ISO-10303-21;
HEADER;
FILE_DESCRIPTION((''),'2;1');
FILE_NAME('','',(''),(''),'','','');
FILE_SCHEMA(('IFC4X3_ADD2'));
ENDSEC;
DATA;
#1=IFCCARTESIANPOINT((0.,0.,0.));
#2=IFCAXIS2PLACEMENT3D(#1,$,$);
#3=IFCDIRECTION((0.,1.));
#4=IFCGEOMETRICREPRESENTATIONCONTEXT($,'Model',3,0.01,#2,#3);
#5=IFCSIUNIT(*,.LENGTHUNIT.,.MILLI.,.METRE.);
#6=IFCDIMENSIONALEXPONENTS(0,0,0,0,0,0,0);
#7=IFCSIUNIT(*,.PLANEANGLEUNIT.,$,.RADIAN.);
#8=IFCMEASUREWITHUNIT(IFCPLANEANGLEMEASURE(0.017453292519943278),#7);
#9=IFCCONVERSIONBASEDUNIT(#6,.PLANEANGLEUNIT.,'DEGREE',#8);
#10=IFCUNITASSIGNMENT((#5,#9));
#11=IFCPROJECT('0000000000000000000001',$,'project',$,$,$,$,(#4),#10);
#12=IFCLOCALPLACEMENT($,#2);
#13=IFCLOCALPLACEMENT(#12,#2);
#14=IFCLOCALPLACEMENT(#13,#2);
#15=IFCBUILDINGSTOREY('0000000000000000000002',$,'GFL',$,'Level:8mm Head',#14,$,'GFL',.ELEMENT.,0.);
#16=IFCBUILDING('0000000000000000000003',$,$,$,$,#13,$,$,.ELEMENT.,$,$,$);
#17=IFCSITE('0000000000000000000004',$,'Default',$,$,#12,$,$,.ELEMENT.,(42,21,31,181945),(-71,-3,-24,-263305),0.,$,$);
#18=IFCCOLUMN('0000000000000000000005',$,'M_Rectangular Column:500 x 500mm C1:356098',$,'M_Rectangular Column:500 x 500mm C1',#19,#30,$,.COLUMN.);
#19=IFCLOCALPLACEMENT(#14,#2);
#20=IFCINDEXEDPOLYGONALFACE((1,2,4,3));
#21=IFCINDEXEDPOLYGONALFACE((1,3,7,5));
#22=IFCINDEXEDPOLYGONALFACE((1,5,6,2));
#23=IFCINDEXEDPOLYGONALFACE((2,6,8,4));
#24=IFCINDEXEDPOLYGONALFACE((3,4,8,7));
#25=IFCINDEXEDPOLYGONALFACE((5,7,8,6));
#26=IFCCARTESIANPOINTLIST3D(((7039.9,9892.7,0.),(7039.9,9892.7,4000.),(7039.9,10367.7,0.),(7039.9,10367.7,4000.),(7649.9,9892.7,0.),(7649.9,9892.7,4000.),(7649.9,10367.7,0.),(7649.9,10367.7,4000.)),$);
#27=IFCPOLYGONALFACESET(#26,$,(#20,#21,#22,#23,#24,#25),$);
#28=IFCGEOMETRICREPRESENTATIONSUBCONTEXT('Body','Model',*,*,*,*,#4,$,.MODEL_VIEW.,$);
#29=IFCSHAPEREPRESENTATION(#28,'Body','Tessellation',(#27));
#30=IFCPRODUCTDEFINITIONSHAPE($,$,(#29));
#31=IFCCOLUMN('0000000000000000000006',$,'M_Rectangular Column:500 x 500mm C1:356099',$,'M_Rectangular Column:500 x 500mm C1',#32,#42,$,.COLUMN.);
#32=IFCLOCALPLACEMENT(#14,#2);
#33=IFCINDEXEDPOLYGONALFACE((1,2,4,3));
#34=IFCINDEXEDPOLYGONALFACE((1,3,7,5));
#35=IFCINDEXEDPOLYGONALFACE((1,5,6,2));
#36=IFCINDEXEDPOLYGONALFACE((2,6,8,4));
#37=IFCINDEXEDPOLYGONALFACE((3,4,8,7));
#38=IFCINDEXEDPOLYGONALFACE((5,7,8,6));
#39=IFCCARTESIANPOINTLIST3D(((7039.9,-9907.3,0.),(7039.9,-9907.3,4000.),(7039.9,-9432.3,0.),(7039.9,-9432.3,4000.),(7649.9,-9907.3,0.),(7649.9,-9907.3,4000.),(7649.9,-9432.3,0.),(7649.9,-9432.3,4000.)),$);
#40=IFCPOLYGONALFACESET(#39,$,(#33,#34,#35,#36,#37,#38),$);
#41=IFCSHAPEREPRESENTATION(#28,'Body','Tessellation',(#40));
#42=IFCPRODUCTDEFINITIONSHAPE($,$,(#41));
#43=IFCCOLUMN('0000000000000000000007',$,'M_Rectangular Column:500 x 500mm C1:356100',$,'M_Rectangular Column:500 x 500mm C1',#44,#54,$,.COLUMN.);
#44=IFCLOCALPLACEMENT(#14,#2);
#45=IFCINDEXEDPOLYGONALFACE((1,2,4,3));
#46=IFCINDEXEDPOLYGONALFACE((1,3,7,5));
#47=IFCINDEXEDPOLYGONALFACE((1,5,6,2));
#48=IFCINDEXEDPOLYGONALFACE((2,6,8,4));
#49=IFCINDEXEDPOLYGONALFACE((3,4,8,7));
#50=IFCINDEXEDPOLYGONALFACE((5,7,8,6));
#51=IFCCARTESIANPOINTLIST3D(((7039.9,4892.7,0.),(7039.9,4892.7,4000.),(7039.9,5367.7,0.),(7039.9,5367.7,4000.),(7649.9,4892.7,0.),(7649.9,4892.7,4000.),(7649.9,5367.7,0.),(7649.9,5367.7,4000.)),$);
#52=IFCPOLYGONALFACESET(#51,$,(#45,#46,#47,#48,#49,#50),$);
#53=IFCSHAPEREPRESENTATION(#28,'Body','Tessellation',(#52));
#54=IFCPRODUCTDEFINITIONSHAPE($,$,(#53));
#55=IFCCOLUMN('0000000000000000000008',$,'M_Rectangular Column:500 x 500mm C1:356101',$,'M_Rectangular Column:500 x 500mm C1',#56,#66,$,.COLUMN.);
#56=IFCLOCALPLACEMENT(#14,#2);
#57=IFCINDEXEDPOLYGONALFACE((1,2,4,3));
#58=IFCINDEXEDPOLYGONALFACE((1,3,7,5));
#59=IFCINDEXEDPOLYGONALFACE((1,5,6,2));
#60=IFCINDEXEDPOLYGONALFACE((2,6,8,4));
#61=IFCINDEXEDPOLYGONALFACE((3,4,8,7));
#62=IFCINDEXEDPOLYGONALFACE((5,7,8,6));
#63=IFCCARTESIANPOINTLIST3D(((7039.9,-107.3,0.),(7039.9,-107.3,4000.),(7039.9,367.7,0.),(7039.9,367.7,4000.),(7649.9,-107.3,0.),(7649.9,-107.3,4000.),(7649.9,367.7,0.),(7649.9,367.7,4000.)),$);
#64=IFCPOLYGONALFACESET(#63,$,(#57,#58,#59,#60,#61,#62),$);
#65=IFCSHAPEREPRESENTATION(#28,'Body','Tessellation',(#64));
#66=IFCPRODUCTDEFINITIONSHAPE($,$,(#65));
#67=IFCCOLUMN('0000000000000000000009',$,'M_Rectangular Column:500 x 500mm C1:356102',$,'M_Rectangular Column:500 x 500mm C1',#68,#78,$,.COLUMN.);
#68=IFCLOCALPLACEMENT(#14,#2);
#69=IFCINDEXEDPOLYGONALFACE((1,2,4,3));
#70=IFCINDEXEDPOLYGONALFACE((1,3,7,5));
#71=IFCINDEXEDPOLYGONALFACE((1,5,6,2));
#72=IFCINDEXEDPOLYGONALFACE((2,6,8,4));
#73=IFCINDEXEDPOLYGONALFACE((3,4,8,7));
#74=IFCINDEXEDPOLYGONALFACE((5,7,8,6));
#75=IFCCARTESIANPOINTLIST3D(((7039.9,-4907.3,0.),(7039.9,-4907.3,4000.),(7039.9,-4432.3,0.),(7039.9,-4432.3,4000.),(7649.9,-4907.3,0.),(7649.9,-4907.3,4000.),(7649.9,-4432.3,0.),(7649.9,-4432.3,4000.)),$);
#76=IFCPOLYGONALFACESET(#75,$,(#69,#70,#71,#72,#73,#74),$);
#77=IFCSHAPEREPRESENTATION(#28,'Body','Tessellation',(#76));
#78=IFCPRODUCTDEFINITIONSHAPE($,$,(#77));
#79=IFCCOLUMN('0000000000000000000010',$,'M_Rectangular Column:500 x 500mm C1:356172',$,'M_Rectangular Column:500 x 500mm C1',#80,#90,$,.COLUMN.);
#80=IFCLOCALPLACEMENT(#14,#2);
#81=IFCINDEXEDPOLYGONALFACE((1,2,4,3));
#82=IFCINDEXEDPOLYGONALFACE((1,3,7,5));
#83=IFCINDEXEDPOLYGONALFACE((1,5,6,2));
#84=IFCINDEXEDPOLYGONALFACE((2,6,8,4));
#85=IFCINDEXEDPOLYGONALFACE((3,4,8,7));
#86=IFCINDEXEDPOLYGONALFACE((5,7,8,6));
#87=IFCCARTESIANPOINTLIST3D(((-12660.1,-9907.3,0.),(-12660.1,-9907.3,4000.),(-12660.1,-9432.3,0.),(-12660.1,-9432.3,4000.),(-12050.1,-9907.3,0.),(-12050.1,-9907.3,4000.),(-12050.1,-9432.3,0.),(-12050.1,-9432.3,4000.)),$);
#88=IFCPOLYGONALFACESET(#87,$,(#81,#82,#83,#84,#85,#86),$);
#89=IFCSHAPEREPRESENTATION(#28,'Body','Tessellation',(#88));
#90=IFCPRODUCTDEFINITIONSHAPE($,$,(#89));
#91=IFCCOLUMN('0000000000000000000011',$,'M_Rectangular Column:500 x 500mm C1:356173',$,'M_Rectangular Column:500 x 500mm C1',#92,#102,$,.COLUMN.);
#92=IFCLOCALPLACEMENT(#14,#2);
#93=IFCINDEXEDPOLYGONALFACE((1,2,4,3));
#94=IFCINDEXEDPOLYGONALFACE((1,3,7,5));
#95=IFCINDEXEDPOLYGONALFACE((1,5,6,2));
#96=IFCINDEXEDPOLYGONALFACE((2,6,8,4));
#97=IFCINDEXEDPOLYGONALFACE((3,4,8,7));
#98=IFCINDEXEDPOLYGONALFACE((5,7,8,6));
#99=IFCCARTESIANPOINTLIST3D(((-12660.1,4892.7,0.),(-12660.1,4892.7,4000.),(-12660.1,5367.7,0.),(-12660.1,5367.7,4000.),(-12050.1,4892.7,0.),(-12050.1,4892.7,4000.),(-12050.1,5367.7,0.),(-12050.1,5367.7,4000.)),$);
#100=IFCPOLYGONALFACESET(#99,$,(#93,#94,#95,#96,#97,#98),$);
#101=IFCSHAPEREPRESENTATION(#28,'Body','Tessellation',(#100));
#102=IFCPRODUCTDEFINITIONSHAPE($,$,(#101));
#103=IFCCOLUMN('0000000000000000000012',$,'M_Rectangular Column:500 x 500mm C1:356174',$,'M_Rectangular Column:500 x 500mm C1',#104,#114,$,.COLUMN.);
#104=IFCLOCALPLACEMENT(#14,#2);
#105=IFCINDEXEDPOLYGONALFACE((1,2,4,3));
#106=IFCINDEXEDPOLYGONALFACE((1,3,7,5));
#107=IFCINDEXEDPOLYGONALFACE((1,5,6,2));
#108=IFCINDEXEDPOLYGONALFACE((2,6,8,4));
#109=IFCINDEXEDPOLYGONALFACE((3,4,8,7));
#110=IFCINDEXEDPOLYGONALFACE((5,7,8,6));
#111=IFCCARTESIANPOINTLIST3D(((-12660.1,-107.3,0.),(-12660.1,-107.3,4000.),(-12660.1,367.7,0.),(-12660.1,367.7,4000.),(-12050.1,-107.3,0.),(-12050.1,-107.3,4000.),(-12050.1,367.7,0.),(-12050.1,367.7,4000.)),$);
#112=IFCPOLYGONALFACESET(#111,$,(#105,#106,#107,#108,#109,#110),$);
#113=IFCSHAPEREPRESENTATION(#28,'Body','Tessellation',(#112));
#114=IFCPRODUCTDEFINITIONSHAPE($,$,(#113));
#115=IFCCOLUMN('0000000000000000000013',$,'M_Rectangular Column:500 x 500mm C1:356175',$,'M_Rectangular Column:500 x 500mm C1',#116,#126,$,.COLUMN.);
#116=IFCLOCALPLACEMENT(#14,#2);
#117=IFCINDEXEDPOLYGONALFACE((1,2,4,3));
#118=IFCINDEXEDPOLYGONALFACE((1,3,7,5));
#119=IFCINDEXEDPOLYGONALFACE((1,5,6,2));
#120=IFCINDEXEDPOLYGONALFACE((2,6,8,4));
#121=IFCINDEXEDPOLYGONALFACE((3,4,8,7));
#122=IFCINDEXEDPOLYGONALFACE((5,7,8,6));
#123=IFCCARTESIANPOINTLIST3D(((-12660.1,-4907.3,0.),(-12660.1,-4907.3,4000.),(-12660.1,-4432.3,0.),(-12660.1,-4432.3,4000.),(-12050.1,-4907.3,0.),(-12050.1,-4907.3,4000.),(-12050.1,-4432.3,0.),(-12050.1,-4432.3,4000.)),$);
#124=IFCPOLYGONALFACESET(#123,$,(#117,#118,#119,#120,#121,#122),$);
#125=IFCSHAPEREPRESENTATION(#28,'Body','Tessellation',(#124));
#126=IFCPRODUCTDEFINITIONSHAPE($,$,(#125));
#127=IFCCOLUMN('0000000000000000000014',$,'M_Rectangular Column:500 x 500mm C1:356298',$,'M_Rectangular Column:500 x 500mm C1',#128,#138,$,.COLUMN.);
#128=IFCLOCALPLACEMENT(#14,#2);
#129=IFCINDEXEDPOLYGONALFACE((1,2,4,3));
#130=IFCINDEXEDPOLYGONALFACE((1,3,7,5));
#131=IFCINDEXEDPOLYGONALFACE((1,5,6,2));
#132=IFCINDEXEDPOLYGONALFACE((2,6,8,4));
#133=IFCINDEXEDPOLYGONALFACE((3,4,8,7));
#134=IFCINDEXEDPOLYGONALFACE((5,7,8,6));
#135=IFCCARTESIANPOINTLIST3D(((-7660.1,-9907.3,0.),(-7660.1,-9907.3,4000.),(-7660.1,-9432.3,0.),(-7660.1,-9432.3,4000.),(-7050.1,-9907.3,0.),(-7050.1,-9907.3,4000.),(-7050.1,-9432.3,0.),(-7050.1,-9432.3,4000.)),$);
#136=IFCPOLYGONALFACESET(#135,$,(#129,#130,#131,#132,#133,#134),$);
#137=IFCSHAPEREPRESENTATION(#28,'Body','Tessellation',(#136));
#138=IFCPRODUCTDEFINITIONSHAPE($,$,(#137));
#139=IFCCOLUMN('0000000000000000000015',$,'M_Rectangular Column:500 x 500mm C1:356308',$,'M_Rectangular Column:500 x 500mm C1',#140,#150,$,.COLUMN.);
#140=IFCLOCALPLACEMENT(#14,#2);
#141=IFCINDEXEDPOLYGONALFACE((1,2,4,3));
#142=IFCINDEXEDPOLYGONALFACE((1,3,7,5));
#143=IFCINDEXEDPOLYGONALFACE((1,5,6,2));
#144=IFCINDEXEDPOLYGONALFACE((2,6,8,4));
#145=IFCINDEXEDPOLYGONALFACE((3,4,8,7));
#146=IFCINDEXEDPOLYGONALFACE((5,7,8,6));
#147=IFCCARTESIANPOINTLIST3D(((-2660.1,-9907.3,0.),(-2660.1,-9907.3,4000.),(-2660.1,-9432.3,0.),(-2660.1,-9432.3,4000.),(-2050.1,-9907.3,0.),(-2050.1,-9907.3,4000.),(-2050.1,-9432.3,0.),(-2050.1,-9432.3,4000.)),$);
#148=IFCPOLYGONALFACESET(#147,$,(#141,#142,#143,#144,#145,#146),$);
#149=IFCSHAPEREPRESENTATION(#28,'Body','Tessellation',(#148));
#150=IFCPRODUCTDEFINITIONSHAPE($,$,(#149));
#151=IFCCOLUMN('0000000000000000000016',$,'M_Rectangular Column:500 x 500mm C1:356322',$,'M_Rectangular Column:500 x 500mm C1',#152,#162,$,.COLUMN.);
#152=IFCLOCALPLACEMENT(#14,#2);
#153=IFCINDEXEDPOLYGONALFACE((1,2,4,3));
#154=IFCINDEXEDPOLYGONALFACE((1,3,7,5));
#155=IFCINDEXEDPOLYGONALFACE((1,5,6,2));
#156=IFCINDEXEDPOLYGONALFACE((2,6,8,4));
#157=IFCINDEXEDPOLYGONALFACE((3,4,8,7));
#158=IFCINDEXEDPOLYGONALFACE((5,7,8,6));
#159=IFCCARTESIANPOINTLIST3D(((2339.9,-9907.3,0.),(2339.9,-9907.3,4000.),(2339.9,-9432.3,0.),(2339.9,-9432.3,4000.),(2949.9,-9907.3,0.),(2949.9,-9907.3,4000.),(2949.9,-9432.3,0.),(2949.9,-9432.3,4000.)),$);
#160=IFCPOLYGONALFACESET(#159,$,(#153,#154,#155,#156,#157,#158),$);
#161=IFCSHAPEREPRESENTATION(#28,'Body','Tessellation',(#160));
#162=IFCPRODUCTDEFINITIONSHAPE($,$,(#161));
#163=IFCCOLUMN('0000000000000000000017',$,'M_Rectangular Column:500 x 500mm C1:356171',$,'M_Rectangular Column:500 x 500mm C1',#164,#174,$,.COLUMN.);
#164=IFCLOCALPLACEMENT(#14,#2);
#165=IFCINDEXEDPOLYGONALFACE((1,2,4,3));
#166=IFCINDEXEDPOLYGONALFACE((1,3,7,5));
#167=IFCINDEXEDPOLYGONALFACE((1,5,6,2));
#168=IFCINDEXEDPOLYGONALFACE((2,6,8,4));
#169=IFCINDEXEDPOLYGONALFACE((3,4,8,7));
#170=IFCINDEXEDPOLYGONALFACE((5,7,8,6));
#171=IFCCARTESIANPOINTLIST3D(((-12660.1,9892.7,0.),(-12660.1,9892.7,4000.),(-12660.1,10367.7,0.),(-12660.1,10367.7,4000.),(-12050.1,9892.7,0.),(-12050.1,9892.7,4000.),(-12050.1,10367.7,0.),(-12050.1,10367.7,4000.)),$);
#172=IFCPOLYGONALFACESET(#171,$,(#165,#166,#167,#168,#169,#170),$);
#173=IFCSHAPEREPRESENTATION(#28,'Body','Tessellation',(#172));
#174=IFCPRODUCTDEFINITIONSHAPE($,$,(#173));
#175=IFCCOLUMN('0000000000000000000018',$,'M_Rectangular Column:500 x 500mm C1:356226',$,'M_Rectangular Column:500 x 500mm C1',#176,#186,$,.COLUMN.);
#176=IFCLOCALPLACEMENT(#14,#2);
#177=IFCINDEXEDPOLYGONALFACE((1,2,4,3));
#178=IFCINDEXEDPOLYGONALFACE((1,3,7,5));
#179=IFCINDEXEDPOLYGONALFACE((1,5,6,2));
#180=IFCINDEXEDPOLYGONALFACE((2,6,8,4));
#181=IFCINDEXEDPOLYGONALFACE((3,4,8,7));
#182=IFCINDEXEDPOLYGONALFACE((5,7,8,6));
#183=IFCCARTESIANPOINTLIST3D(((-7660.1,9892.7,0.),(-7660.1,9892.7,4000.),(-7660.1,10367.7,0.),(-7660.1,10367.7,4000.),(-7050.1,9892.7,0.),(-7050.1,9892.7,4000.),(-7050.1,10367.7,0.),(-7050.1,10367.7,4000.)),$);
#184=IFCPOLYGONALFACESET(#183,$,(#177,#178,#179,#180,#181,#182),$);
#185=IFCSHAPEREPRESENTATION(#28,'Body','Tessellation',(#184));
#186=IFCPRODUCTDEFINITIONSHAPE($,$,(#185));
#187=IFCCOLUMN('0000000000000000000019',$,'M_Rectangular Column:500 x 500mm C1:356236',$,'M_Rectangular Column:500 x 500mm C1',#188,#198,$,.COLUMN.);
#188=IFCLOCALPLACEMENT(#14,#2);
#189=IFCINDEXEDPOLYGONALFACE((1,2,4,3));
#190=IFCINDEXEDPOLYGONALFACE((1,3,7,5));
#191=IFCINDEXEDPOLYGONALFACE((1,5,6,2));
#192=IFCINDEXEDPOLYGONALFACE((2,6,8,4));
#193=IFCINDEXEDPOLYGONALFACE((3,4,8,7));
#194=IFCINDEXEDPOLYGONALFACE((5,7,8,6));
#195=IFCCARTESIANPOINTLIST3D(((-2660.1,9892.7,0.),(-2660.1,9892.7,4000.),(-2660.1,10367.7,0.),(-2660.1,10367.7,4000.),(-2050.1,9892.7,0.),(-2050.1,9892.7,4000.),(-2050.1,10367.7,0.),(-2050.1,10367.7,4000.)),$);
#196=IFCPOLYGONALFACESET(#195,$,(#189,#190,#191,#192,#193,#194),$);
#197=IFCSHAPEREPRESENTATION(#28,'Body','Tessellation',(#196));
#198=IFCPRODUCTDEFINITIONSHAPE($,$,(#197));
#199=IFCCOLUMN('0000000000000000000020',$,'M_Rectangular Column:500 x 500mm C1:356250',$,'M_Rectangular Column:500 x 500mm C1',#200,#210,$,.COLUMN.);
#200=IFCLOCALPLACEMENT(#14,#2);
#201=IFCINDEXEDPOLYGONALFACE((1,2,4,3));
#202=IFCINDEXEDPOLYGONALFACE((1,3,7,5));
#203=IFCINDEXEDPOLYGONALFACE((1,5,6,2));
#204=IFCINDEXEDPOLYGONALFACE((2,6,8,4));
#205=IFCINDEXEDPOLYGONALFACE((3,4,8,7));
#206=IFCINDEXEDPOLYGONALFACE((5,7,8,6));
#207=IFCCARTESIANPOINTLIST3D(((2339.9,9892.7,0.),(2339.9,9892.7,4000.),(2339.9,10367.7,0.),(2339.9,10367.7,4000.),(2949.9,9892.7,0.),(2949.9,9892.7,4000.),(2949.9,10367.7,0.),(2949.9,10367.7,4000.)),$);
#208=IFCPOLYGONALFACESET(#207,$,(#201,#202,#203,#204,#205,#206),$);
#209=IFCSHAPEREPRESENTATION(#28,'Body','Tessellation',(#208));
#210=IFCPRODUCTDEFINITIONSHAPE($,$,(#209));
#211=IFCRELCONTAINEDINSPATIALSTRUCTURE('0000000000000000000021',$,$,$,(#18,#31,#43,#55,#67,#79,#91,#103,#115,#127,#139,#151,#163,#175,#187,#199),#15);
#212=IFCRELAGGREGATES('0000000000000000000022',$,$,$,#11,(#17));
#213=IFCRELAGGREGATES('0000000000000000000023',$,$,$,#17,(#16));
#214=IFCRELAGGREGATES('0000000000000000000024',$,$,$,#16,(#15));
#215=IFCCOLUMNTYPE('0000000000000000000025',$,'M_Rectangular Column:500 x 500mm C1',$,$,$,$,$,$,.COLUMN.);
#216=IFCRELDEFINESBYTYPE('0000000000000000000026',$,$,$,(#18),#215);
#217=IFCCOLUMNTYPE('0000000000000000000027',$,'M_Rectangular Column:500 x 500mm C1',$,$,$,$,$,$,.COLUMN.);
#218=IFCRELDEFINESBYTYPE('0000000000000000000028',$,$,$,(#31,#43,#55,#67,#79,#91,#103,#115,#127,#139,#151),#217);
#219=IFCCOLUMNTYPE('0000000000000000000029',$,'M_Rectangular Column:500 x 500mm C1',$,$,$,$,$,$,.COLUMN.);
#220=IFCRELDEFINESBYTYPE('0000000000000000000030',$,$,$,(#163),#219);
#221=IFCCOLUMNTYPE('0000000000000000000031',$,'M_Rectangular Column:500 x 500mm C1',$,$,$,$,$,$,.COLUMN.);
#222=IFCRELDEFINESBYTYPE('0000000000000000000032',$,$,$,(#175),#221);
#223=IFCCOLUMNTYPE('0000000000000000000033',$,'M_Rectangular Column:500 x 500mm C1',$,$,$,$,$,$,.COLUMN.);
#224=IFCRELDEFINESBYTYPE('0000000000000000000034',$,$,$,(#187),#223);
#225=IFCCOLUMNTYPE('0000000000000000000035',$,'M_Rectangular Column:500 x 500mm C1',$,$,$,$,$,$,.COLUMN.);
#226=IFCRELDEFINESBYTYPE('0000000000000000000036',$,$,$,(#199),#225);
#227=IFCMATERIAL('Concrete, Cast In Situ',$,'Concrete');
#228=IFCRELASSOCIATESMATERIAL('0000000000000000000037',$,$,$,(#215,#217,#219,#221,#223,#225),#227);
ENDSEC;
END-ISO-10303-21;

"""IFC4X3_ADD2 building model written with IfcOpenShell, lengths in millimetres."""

from ifc_helpers import new_model, entity, si_unit, converted_unit, direction, frame, frame_2d, origin, origin_2d_with_axis, place, context, subcontext, project, spatial, rectangle, extrude, source, transform, mapped, material, material_profile, profile_set, type_object, type_shapes, element, save


model = new_model("IFC4X3_ADD2")

# Units and contexts
model_context = context("Model", 3, precision=0.01, world=origin(), true_north=direction((0.0, 1.0)))
body_context = subcontext(model_context, "Body", "Model", "MODEL_VIEW")
ifc_project = project(units=[si_unit("LENGTHUNIT", "METRE", prefix="MILLI"), converted_unit("PLANEANGLEUNIT", "DEGREE", entity("IfcPlaneAngleMeasure", 0.017453292519943278), si_unit("PLANEANGLEUNIT", "RADIAN"), dimensions=[0, 0, 0, 0, 0, 0, 0])], contexts=[model_context])

# Site, building, storey
site_placement = place(None, origin())
site = spatial("IfcSite", under=ifc_project, at=site_placement, Name="Default", CompositionType="ELEMENT", RefLatitude=(42, 21, 31, 181945), RefLongitude=(-71, -3, -24, -263305), RefElevation=0.0)
building_placement = place(site_placement, origin())
building = spatial("IfcBuilding", under=site, at=building_placement, CompositionType="ELEMENT")
storey_placement = place(building_placement, origin())
storey = spatial("IfcBuildingStorey", under=building, at=storey_placement, Name="GFL", ObjectType="Level:8mm Head", LongName="GFL", CompositionType="ELEMENT", Elevation=0.0)

# Columns
ifc_material_1 = material(Name="Concrete, Cast In Situ", Category="Concrete")
ifc_material_profile_1 = material_profile(ifc_material_1, rectangle(XDim=610.0, YDim=475.0, at=frame_2d((0.0, 0.0), x_axis=(1.0, 0.0))), Name="500 x 500mm C1")
ifc_profile_set_1 = profile_set([ifc_material_profile_1], Name="500 x 500mm C1")
column_type_1 = type_object("IfcColumnType", Name="M_Rectangular Column:500 x 500mm C1", PredefinedType="COLUMN", material=ifc_profile_set_1)
shared_shape_1 = source(origin(), body_context, "Body", "SweptSolid", [
    extrude(rectangle(XDim=610.0, YDim=475.0, at=frame_2d((0.0, 0.0), x_axis=(1.0, 0.0))), frame((7344.9, 10130.2, 0.0), z_axis=(0.0, 0.0, 1.0), x_axis=(-1.0, 0.0, 0.0)), (0.0, 0.0, 1.0), 4000.0),
])
type_shapes(column_type_1, [shared_shape_1])
column_1_placement = place(storey_placement, origin())
element("IfcColumn", 1, at=column_1_placement, inside=storey, type_object=column_type_1, Name="M_Rectangular Column:500 x 500mm C1:356098", ObjectType="M_Rectangular Column:500 x 500mm C1", PredefinedType="COLUMN", context=body_context, shape_type="MappedRepresentation", body=[
    mapped(shared_shape_1, transform((0.0, 0.0, 0.0), scale=1.0)),
])
column_type_2 = type_object("IfcColumnType", Name="M_Rectangular Column:500 x 500mm C1", PredefinedType="COLUMN", material=ifc_profile_set_1)
shared_shape_2 = source(origin(), body_context, "Body", "SweptSolid", [
    extrude(rectangle(XDim=610.0, YDim=475.0, at=origin_2d_with_axis()), frame((0.0, 0.0, 0.0), z_axis=(0.0, 0.0, 1.0), x_axis=(-1.0, 0.0, 0.0)), (0.0, 0.0, 1.0), 4000.0),
])
type_shapes(column_type_2, [shared_shape_2])
for number, where, name in (
    (2, (7344.9, -9669.8, 0.0), "M_Rectangular Column:500 x 500mm C1:356099"),
    (3, (7344.9, 5130.2, 0.0), "M_Rectangular Column:500 x 500mm C1:356100"),
    (4, (7344.9, 130.2, 0.0), "M_Rectangular Column:500 x 500mm C1:356101"),
    (5, (7344.9, -4669.8, 0.0), "M_Rectangular Column:500 x 500mm C1:356102"),
    (6, (-12355.1, -9669.8, 0.0), "M_Rectangular Column:500 x 500mm C1:356172"),
    (7, (-12355.1, 5130.2, 0.0), "M_Rectangular Column:500 x 500mm C1:356173"),
    (8, (-12355.1, 130.2, 0.0), "M_Rectangular Column:500 x 500mm C1:356174"),
    (9, (-12355.1, -4669.8, 0.0), "M_Rectangular Column:500 x 500mm C1:356175"),
    (10, (-7355.1, -9669.8, 0.0), "M_Rectangular Column:500 x 500mm C1:356298"),
    (11, (-2355.1, -9669.8, 0.0), "M_Rectangular Column:500 x 500mm C1:356308"),
    (12, (2644.9, -9669.8, 0.0), "M_Rectangular Column:500 x 500mm C1:356322"),
):
    element("IfcColumn", number, at=place(storey_placement, frame(where)), inside=storey, type_object=column_type_2, Name=name, ObjectType="M_Rectangular Column:500 x 500mm C1", PredefinedType="COLUMN", context=body_context, shape_type="MappedRepresentation", body=[
        mapped(shared_shape_2, transform((0.0, 0.0, 0.0), scale=1.0)),
    ])
column_type_3 = type_object("IfcColumnType", Name="M_Rectangular Column:500 x 500mm C1", PredefinedType="COLUMN", material=ifc_profile_set_1)
shared_shape_3 = source(origin(), body_context, "Body", "SweptSolid", [
    extrude(rectangle(XDim=610.0, YDim=475.0, at=frame_2d((0.0, 0.0), x_axis=(1.0, 0.0))), frame((-12355.1, 10130.2, 0.0), z_axis=(0.0, 0.0, 1.0), x_axis=(-1.0, 0.0, 0.0)), (0.0, 0.0, 1.0), 4000.0),
])
type_shapes(column_type_3, [shared_shape_3])
column_2_placement = place(storey_placement, origin())
element("IfcColumn", 13, at=column_2_placement, inside=storey, type_object=column_type_3, Name="M_Rectangular Column:500 x 500mm C1:356171", ObjectType="M_Rectangular Column:500 x 500mm C1", PredefinedType="COLUMN", context=body_context, shape_type="MappedRepresentation", body=[
    mapped(shared_shape_3, transform((0.0, 0.0, 0.0), scale=1.0)),
])
column_type_4 = type_object("IfcColumnType", Name="M_Rectangular Column:500 x 500mm C1", PredefinedType="COLUMN", material=ifc_profile_set_1)
shared_shape_4 = source(origin(), body_context, "Body", "SweptSolid", [
    extrude(rectangle(XDim=610.0, YDim=475.0, at=frame_2d((0.0, 0.0), x_axis=(1.0, 0.0))), frame((-7355.1, 10130.2, 0.0), z_axis=(0.0, 0.0, 1.0), x_axis=(-1.0, 0.0, 0.0)), (0.0, 0.0, 1.0), 4000.0),
])
type_shapes(column_type_4, [shared_shape_4])
column_3_placement = place(storey_placement, origin())
element("IfcColumn", 14, at=column_3_placement, inside=storey, type_object=column_type_4, Name="M_Rectangular Column:500 x 500mm C1:356226", ObjectType="M_Rectangular Column:500 x 500mm C1", PredefinedType="COLUMN", context=body_context, shape_type="MappedRepresentation", body=[
    mapped(shared_shape_4, transform((0.0, 0.0, 0.0), scale=1.0)),
])
column_type_5 = type_object("IfcColumnType", Name="M_Rectangular Column:500 x 500mm C1", PredefinedType="COLUMN", material=ifc_profile_set_1)
shared_shape_5 = source(origin(), body_context, "Body", "SweptSolid", [
    extrude(rectangle(XDim=610.0, YDim=475.0, at=frame_2d((0.0, 0.0), x_axis=(1.0, 0.0))), frame((-2355.1, 10130.2, 0.0), z_axis=(0.0, 0.0, 1.0), x_axis=(-1.0, 0.0, 0.0)), (0.0, 0.0, 1.0), 4000.0),
])
type_shapes(column_type_5, [shared_shape_5])
column_4_placement = place(storey_placement, origin())
element("IfcColumn", 15, at=column_4_placement, inside=storey, type_object=column_type_5, Name="M_Rectangular Column:500 x 500mm C1:356236", ObjectType="M_Rectangular Column:500 x 500mm C1", PredefinedType="COLUMN", context=body_context, shape_type="MappedRepresentation", body=[
    mapped(shared_shape_5, transform((0.0, 0.0, 0.0), scale=1.0)),
])
column_type_6 = type_object("IfcColumnType", Name="M_Rectangular Column:500 x 500mm C1", PredefinedType="COLUMN", material=ifc_profile_set_1)
shared_shape_6 = source(origin(), body_context, "Body", "SweptSolid", [
    extrude(rectangle(XDim=610.0, YDim=475.0, at=frame_2d((0.0, 0.0), x_axis=(1.0, 0.0))), frame((2644.9, 10130.2, 0.0), z_axis=(0.0, 0.0, 1.0), x_axis=(-1.0, 0.0, 0.0)), (0.0, 0.0, 1.0), 4000.0),
])
type_shapes(column_type_6, [shared_shape_6])
column_5_placement = place(storey_placement, origin())
element("IfcColumn", 16, at=column_5_placement, inside=storey, type_object=column_type_6, Name="M_Rectangular Column:500 x 500mm C1:356250", ObjectType="M_Rectangular Column:500 x 500mm C1", PredefinedType="COLUMN", context=body_context, shape_type="MappedRepresentation", body=[
    mapped(shared_shape_6, transform((0.0, 0.0, 0.0), scale=1.0)),
])

save(model, "model.ifc")
